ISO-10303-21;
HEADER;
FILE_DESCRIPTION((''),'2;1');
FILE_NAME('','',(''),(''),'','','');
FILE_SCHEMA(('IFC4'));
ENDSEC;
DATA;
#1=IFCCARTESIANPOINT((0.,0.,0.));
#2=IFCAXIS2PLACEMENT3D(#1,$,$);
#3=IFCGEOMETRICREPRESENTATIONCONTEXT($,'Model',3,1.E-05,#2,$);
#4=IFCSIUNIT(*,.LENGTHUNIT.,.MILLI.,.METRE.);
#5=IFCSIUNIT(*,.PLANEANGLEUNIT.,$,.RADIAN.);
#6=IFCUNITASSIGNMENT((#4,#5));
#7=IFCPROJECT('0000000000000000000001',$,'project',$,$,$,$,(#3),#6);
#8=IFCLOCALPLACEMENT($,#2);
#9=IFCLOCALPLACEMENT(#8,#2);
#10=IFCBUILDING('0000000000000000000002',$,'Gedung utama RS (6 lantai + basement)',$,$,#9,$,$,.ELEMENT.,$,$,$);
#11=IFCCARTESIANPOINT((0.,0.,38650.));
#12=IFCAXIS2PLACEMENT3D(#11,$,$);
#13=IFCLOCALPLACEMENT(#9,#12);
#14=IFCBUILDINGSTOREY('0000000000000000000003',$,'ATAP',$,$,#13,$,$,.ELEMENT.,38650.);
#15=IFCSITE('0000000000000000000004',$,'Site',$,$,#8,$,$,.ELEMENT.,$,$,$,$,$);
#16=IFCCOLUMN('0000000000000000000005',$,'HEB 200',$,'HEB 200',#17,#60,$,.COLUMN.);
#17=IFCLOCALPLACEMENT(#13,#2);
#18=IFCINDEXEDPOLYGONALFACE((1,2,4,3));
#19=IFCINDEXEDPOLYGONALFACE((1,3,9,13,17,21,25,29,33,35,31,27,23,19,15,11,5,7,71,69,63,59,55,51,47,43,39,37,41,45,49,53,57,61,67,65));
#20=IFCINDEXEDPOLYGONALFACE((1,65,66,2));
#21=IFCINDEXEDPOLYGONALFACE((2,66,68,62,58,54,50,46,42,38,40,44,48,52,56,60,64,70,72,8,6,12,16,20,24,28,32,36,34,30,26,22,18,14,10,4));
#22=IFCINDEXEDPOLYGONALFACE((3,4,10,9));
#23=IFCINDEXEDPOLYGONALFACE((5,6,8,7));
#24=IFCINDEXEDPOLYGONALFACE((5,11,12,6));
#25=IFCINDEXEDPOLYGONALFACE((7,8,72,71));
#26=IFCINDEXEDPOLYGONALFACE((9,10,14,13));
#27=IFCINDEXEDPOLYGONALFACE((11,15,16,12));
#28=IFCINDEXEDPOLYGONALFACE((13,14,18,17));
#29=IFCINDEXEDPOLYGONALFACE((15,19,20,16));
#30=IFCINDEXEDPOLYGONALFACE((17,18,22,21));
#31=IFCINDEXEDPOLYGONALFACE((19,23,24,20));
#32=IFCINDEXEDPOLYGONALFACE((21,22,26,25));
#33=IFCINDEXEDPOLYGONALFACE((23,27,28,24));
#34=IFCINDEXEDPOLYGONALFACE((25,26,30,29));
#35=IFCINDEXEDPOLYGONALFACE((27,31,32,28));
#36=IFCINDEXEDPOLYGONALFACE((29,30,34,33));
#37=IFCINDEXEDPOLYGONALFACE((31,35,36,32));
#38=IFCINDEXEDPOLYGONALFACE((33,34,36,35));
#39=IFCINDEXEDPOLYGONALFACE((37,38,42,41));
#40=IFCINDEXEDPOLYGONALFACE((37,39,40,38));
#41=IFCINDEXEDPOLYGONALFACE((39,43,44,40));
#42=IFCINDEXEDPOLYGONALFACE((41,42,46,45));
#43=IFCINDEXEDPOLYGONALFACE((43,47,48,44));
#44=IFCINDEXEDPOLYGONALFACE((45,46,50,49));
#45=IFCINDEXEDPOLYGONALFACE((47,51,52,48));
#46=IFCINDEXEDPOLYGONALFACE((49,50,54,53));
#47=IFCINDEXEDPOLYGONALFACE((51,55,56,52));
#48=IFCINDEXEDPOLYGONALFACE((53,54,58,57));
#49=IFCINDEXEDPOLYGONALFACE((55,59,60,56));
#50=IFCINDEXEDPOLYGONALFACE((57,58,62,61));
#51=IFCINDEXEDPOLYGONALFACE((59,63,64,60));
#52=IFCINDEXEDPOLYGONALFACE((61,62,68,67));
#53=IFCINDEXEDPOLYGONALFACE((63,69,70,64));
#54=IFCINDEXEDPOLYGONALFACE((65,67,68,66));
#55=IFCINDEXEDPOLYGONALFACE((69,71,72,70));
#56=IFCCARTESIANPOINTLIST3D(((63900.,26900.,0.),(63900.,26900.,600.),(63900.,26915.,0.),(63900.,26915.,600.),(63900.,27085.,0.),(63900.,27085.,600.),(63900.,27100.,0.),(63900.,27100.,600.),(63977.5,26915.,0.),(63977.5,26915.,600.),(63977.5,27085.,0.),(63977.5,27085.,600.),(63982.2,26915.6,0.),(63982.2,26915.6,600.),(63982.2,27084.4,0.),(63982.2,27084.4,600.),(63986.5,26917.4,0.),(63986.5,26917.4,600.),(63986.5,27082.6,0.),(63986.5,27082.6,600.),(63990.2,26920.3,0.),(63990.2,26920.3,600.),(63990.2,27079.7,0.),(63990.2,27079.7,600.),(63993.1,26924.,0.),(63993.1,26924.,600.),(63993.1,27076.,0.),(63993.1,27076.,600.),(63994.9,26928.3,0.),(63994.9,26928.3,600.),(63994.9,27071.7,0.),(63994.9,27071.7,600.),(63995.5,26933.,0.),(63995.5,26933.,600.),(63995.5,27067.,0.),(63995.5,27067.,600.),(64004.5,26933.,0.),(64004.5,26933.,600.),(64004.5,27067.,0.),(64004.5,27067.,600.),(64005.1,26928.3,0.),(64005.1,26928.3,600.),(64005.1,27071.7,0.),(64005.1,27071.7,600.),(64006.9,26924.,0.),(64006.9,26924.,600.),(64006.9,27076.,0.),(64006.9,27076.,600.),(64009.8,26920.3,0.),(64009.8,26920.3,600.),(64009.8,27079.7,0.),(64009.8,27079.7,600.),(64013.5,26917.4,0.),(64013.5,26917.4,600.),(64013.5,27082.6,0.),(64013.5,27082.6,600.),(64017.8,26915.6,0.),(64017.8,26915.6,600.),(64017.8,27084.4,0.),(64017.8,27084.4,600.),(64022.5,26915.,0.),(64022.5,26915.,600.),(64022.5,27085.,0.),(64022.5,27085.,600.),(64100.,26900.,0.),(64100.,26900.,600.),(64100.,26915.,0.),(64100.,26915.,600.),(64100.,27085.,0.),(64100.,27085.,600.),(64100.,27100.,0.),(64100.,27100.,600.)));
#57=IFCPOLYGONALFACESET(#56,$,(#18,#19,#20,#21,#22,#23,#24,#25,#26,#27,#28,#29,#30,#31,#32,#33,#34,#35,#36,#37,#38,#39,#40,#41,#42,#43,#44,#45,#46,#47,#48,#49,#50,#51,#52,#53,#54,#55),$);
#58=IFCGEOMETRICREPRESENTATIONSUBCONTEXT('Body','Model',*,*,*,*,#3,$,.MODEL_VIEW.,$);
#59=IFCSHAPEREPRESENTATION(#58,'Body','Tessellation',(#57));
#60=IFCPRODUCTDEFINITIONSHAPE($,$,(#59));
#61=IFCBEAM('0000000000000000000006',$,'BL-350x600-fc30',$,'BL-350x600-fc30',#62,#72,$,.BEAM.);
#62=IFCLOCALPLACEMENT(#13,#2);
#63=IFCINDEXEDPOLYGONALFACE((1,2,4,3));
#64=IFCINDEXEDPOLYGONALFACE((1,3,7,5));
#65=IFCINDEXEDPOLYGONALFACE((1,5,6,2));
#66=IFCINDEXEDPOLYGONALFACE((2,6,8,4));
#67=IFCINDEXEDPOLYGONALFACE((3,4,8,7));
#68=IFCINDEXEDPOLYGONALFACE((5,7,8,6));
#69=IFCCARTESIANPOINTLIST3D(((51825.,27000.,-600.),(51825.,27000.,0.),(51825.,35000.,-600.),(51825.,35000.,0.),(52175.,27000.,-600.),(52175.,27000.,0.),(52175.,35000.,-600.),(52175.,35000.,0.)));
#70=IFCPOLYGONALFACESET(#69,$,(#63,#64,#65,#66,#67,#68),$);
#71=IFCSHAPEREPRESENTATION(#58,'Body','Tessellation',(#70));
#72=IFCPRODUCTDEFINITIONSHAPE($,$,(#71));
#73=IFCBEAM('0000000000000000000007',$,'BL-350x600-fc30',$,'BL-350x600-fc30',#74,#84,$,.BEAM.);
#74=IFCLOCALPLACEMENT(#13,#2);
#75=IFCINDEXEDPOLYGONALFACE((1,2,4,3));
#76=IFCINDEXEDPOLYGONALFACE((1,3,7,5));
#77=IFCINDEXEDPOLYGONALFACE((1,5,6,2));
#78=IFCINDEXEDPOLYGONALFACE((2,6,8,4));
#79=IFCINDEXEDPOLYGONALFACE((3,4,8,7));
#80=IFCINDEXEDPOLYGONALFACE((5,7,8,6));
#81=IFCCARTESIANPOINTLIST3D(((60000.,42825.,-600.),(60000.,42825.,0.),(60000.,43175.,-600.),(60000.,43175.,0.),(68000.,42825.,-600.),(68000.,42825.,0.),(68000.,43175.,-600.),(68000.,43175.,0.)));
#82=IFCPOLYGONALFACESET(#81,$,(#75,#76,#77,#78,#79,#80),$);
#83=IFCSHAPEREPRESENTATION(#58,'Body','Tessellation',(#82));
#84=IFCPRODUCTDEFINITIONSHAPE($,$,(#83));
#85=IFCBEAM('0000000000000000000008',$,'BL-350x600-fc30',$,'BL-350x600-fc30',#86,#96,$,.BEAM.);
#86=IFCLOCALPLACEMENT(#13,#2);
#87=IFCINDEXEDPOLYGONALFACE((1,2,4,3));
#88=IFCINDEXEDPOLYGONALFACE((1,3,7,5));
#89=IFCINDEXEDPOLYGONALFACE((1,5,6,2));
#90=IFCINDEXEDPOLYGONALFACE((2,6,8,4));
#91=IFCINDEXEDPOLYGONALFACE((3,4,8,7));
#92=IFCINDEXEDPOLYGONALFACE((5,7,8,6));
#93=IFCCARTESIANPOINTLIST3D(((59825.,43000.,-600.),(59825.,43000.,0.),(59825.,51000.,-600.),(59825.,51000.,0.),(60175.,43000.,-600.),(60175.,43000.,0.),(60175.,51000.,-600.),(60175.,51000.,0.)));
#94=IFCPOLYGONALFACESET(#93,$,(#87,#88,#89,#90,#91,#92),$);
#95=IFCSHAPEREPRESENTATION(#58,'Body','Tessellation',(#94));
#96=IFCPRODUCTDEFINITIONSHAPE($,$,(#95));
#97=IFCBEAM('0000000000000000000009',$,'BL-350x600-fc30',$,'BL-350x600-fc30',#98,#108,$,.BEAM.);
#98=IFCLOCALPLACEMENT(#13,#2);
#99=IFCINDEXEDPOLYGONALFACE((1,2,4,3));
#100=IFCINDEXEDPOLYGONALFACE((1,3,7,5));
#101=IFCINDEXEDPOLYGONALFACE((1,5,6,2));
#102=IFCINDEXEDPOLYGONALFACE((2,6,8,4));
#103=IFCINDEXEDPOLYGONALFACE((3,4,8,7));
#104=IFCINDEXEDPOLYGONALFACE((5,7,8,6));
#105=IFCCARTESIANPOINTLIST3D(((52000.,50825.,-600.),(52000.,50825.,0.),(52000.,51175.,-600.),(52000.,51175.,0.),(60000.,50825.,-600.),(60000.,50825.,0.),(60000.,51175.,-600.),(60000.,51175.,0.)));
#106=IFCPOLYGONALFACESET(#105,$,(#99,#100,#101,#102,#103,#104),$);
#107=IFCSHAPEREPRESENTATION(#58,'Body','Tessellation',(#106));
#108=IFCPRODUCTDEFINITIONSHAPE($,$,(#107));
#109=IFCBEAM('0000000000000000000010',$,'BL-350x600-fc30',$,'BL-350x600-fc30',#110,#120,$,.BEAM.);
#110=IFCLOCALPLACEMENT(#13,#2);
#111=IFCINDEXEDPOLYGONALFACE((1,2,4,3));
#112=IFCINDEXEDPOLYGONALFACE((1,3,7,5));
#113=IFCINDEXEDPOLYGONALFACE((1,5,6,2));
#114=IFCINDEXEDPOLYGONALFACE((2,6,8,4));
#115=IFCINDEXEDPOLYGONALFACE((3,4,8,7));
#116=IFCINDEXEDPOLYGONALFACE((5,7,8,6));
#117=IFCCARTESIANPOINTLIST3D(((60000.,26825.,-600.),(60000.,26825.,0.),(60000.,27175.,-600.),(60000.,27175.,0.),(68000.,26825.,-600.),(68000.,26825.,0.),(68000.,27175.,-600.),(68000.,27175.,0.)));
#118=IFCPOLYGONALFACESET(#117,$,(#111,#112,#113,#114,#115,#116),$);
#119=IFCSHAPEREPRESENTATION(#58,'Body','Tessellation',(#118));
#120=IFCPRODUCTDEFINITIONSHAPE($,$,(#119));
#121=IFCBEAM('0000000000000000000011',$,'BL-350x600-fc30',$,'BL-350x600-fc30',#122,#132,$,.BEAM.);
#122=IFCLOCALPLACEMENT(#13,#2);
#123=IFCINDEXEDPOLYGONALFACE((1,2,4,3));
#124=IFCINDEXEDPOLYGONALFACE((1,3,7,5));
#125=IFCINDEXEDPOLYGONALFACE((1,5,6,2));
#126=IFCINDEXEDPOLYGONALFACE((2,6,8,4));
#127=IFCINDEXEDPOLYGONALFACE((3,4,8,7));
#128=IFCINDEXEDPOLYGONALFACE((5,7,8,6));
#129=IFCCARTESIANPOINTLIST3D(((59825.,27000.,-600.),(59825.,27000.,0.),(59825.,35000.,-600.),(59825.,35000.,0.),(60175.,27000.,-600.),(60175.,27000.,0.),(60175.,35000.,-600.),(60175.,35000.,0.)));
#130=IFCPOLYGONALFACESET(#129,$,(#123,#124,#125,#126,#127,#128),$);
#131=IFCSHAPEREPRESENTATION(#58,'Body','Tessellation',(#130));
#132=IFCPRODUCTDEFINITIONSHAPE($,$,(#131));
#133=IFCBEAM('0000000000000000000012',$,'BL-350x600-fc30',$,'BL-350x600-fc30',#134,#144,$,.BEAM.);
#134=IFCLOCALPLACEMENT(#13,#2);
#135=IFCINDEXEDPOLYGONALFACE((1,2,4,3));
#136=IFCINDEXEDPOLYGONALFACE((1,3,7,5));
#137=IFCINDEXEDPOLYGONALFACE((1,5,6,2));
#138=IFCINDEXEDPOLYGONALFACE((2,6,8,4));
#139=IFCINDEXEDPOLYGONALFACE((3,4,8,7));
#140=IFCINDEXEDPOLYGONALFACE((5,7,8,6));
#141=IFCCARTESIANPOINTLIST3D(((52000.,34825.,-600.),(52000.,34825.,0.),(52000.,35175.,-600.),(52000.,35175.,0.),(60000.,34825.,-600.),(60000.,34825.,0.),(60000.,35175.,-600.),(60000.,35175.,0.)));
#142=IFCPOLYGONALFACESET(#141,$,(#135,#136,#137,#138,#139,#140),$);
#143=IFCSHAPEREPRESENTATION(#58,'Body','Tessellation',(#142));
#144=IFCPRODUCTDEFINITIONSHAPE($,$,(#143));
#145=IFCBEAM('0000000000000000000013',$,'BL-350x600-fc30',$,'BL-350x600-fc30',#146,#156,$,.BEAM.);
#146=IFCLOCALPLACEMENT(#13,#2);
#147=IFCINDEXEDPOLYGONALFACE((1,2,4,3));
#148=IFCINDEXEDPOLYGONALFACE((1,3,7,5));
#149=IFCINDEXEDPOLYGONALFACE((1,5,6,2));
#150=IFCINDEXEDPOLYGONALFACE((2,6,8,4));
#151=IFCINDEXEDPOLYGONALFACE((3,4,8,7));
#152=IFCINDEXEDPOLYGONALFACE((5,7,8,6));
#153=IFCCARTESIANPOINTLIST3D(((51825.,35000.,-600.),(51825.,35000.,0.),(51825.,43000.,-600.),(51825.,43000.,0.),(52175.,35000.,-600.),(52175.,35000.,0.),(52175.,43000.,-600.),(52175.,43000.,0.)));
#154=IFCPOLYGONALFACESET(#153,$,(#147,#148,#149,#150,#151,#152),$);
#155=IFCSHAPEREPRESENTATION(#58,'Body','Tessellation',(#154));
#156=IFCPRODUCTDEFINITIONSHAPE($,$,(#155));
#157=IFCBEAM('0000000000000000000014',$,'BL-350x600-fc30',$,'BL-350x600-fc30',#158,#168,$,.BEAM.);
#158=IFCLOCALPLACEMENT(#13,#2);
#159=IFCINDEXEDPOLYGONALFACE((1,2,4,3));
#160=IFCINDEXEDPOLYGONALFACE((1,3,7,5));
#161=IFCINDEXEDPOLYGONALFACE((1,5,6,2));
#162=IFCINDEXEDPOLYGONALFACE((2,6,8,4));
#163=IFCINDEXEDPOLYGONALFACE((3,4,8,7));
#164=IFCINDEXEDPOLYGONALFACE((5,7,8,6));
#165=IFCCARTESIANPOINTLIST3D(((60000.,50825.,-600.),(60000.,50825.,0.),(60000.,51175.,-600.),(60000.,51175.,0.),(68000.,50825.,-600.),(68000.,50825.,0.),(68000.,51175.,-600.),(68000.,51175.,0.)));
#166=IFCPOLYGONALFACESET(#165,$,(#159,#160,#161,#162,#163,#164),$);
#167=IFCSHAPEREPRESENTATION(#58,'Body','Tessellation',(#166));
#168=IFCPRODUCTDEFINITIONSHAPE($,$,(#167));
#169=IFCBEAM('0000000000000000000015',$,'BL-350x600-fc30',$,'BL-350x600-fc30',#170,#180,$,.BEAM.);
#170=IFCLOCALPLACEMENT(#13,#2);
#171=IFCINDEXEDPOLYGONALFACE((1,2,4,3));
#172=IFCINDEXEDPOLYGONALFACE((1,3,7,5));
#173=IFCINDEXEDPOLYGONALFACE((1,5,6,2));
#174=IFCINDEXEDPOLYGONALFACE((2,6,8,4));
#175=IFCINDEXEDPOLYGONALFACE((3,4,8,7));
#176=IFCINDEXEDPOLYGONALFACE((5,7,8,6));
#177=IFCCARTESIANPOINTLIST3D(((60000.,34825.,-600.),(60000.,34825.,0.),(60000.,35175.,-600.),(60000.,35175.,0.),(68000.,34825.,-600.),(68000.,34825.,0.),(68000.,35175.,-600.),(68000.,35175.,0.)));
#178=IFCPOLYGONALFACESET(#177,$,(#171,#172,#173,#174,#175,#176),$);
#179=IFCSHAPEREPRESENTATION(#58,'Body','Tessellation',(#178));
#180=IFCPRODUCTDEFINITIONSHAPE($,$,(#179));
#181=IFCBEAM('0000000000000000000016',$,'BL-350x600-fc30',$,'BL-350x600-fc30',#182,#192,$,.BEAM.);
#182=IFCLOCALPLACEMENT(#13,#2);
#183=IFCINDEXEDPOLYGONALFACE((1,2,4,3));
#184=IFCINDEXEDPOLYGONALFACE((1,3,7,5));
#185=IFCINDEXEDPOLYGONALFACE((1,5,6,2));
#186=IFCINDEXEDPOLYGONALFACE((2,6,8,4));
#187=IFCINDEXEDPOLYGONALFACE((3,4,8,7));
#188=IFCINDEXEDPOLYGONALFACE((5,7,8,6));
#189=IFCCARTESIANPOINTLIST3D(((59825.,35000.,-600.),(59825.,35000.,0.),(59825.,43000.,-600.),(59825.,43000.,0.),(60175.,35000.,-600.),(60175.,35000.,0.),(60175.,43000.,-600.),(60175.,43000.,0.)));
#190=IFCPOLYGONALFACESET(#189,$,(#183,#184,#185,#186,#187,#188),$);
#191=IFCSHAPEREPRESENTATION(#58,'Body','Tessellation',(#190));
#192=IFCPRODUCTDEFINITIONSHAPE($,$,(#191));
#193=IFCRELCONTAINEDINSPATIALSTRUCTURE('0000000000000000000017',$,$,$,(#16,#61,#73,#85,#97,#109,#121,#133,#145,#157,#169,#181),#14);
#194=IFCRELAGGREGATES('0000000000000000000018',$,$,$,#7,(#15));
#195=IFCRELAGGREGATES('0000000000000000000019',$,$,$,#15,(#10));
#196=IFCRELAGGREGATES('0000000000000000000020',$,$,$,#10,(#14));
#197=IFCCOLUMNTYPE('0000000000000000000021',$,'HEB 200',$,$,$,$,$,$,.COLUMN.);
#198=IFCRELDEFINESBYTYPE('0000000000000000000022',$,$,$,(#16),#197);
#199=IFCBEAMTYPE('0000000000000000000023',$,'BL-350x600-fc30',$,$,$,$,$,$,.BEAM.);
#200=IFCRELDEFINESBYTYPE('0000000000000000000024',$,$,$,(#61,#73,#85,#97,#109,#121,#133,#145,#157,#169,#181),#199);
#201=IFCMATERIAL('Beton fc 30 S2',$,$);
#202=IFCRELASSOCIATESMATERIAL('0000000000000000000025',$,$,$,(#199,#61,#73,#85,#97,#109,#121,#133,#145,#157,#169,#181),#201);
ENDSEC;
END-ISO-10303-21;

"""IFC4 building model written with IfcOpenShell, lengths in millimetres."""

from ifc_helpers import new_model, si_unit, frame, origin, origin_2d, place, context, subcontext, project, spatial, rectangle, i_section, extrude, material, material_profile, profile_set, profile_usage, type_object, element, save


model = new_model("IFC4")

# Units and contexts
model_context = context("Model", 3, precision=1e-05, world=origin())
body_context = subcontext(model_context, "Body", "Model", "MODEL_VIEW")
ifc_project = project(units=[si_unit("LENGTHUNIT", "METRE", prefix="MILLI"), si_unit("PLANEANGLEUNIT", "RADIAN")], contexts=[model_context])

# Site, building, storey
site_placement = place(None, origin())
site = spatial("IfcSite", under=ifc_project, at=site_placement, Name="Site", CompositionType="ELEMENT")
building_placement = place(site_placement, origin())
building = spatial("IfcBuilding", under=site, at=building_placement, Name="Gedung utama RS (6 lantai + basement)", CompositionType="ELEMENT")
storey_placement = place(building_placement, frame((0.0, 0.0, 38650.0)))
storey = spatial("IfcBuildingStorey", under=building, at=storey_placement, Name="ATAP", CompositionType="ELEMENT", Elevation=38650.0)

# Column
ifc_material_profile_1 = material_profile(None, i_section(OverallWidth=200.0, OverallDepth=200.0, WebThickness=9.0, FlangeThickness=15.0, FilletRadius=18.0, at=origin_2d()), Name="HEB 200")
ifc_profile_set_1 = profile_set([ifc_material_profile_1], Name="HEB 200")
ifc_profile_usage_1 = profile_usage(ifc_profile_set_1, cardinal=5)
column_type = type_object("IfcColumnType", Name="HEB 200", PredefinedType="COLUMN", material=ifc_profile_set_1)
for number, where, z_axis, x_axis, name in (
    (1, (64000.0, 27000.0, 0.0), (0.0, 0.0, 1.0), (1.0, 0.0, 0.0), "HEB 200"),
):
    element("IfcColumn", number, at=place(storey_placement, frame(where, z_axis=z_axis, x_axis=x_axis)), inside=storey, type_object=column_type, material=ifc_profile_usage_1, Name=name, ObjectType="HEB 200", PredefinedType="COLUMN", context=body_context, shape_type="SweptSolid", body=[
        extrude(i_section(OverallWidth=200.0, OverallDepth=200.0, WebThickness=9.0, FlangeThickness=15.0, FilletRadius=18.0, at=origin_2d()), origin(), (0.0, 0.0, 1.0), 600.0),
    ])

# Beams
ifc_material = material(Name="Beton fc 30 S2")
ifc_material_profile_2 = material_profile(ifc_material, rectangle(XDim=350.0, YDim=600.0, at=origin_2d()), Name="BL-350x600-fc30")
ifc_profile_set_2 = profile_set([ifc_material_profile_2], Name="BL-350x600-fc30")
ifc_profile_usage_2 = profile_usage(ifc_profile_set_2, cardinal=8)
beam_type = type_object("IfcBeamType", Name="BL-350x600-fc30", PredefinedType="BEAM", material=ifc_profile_set_2)
beam_1_placement = place(storey_placement, frame((52000.0, 27000.0, -300.0)))
element("IfcBeam", 2, at=beam_1_placement, inside=storey, type_object=beam_type, material=ifc_profile_usage_2, Name="BL-350x600-fc30", ObjectType="BL-350x600-fc30", PredefinedType="BEAM", context=body_context, shape_type="SweptSolid", body=[
    extrude(rectangle(XDim=350.0, YDim=600.0, at=origin_2d()), frame((0.0, 0.0, 0.0), z_axis=(0.0, 1.0, 0.0), x_axis=(-1.0, 0.0, 0.0)), (0.0, 0.0, 1.0), 8000.0),
])
beam_2_placement = place(storey_placement, frame((60000.0, 43000.0, -300.0)))
element("IfcBeam", 3, at=beam_2_placement, inside=storey, type_object=beam_type, material=ifc_profile_usage_2, Name="BL-350x600-fc30", ObjectType="BL-350x600-fc30", PredefinedType="BEAM", context=body_context, shape_type="SweptSolid", body=[
    extrude(rectangle(XDim=350.0, YDim=600.0, at=origin_2d()), frame((0.0, 0.0, 0.0), z_axis=(1.0, 0.0, 0.0), x_axis=(0.0, 1.0, 0.0)), (0.0, 0.0, 1.0), 8000.0),
])
beam_3_placement = place(storey_placement, frame((60000.0, 43000.0, -300.0)))
element("IfcBeam", 4, at=beam_3_placement, inside=storey, type_object=beam_type, material=ifc_profile_usage_2, Name="BL-350x600-fc30", ObjectType="BL-350x600-fc30", PredefinedType="BEAM", context=body_context, shape_type="SweptSolid", body=[
    extrude(rectangle(XDim=350.0, YDim=600.0, at=origin_2d()), frame((0.0, 0.0, 0.0), z_axis=(0.0, 1.0, 0.0), x_axis=(-1.0, 0.0, 0.0)), (0.0, 0.0, 1.0), 8000.0),
])
for number, where, name in (
    (5, (52000.0, 51000.0, -300.0), "BL-350x600-fc30"),
    (6, (60000.0, 27000.0, -300.0), "BL-350x600-fc30"),
):
    element("IfcBeam", number, at=place(storey_placement, frame(where)), inside=storey, type_object=beam_type, material=ifc_profile_usage_2, Name=name, ObjectType="BL-350x600-fc30", PredefinedType="BEAM", context=body_context, shape_type="SweptSolid", body=[
        extrude(rectangle(XDim=350.0, YDim=600.0, at=origin_2d()), frame((0.0, 0.0, 0.0), z_axis=(1.0, 0.0, 0.0), x_axis=(0.0, 1.0, 0.0)), (0.0, 0.0, 1.0), 8000.0),
    ])
beam_4_placement = place(storey_placement, frame((60000.0, 27000.0, -300.0)))
element("IfcBeam", 7, at=beam_4_placement, inside=storey, type_object=beam_type, material=ifc_profile_usage_2, Name="BL-350x600-fc30", ObjectType="BL-350x600-fc30", PredefinedType="BEAM", context=body_context, shape_type="SweptSolid", body=[
    extrude(rectangle(XDim=350.0, YDim=600.0, at=origin_2d()), frame((0.0, 0.0, 0.0), z_axis=(0.0, 1.0, 0.0), x_axis=(-1.0, 0.0, 0.0)), (0.0, 0.0, 1.0), 8000.0),
])
beam_5_placement = place(storey_placement, frame((52000.0, 35000.0, -300.0)))
element("IfcBeam", 8, at=beam_5_placement, inside=storey, type_object=beam_type, material=ifc_profile_usage_2, Name="BL-350x600-fc30", ObjectType="BL-350x600-fc30", PredefinedType="BEAM", context=body_context, shape_type="SweptSolid", body=[
    extrude(rectangle(XDim=350.0, YDim=600.0, at=origin_2d()), frame((0.0, 0.0, 0.0), z_axis=(1.0, 0.0, 0.0), x_axis=(0.0, 1.0, 0.0)), (0.0, 0.0, 1.0), 8000.0),
])
beam_6_placement = place(storey_placement, frame((52000.0, 35000.0, -300.0)))
element("IfcBeam", 9, at=beam_6_placement, inside=storey, type_object=beam_type, material=ifc_profile_usage_2, Name="BL-350x600-fc30", ObjectType="BL-350x600-fc30", PredefinedType="BEAM", context=body_context, shape_type="SweptSolid", body=[
    extrude(rectangle(XDim=350.0, YDim=600.0, at=origin_2d()), frame((0.0, 0.0, 0.0), z_axis=(0.0, 1.0, 0.0), x_axis=(-1.0, 0.0, 0.0)), (0.0, 0.0, 1.0), 8000.0),
])
for number, where, name in (
    (10, (60000.0, 51000.0, -300.0), "BL-350x600-fc30"),
    (11, (60000.0, 35000.0, -300.0), "BL-350x600-fc30"),
):
    element("IfcBeam", number, at=place(storey_placement, frame(where)), inside=storey, type_object=beam_type, material=ifc_profile_usage_2, Name=name, ObjectType="BL-350x600-fc30", PredefinedType="BEAM", context=body_context, shape_type="SweptSolid", body=[
        extrude(rectangle(XDim=350.0, YDim=600.0, at=origin_2d()), frame((0.0, 0.0, 0.0), z_axis=(1.0, 0.0, 0.0), x_axis=(0.0, 1.0, 0.0)), (0.0, 0.0, 1.0), 8000.0),
    ])
beam_7_placement = place(storey_placement, frame((60000.0, 35000.0, -300.0)))
element("IfcBeam", 12, at=beam_7_placement, inside=storey, type_object=beam_type, material=ifc_profile_usage_2, Name="BL-350x600-fc30", ObjectType="BL-350x600-fc30", PredefinedType="BEAM", context=body_context, shape_type="SweptSolid", body=[
    extrude(rectangle(XDim=350.0, YDim=600.0, at=origin_2d()), frame((0.0, 0.0, 0.0), z_axis=(0.0, 1.0, 0.0), x_axis=(-1.0, 0.0, 0.0)), (0.0, 0.0, 1.0), 8000.0),
])

save(model, "model.ifc")
